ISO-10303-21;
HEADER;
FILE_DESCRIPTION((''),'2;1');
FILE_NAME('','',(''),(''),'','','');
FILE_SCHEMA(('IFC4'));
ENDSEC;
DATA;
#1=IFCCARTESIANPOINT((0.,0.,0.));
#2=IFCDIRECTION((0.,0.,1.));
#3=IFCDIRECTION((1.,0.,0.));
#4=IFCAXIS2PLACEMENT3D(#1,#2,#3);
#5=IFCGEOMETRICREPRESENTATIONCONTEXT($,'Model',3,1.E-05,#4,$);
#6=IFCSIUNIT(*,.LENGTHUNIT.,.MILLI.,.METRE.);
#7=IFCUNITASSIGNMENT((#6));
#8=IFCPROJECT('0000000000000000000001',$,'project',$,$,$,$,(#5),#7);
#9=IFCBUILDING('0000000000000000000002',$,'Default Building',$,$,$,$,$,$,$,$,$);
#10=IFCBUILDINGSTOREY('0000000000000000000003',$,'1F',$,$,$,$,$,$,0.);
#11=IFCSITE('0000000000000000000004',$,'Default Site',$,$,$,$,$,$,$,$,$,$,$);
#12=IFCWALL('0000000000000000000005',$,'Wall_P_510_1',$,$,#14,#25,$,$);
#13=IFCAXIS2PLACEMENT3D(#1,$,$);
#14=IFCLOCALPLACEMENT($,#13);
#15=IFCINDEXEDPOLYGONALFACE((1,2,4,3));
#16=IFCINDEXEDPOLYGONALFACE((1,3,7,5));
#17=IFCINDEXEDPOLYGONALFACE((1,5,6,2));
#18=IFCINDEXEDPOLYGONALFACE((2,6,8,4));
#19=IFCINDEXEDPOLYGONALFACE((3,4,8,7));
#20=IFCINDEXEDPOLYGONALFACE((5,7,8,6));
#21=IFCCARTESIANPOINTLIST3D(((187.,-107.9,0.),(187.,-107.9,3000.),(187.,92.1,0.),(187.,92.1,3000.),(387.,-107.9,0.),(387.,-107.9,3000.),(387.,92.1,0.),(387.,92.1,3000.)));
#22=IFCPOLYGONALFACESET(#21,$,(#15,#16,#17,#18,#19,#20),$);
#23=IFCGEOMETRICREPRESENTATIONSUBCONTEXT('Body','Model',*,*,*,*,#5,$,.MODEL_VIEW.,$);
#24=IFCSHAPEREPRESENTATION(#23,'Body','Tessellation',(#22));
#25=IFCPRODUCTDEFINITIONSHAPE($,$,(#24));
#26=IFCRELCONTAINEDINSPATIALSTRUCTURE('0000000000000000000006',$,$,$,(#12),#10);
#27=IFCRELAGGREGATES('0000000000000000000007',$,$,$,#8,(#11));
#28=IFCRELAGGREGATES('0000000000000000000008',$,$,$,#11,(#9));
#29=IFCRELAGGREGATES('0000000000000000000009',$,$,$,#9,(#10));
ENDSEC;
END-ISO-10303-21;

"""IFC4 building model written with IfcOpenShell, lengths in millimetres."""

from ifc_helpers import new_model, si_unit, frame, origin_with_axes, place, context, subcontext, project, spatial, indexed_curve, outline, extrude, element, save


model = new_model("IFC4")

# Units and contexts
model_context = context("Model", 3, precision=1e-05, world=origin_with_axes())
body_context = subcontext(model_context, "Body", "Model", "MODEL_VIEW")
ifc_project = project(units=[si_unit("LENGTHUNIT", "METRE", prefix="MILLI")], contexts=[model_context])

# Site, building, storey
site = spatial("IfcSite", under=ifc_project, Name="Default Site")
building = spatial("IfcBuilding", under=site, Name="Default Building")
storey = spatial("IfcBuildingStorey", under=building, Name="1F", Elevation=0.0)

# Wall
wall_1_placement = place(None, frame((187.0, 92.1, 0.0), z_axis=(0.0, 0.0, 1.0), x_axis=(0.0, -1.0, 0.0)))
element("IfcWall", 1, at=wall_1_placement, inside=storey, Name="Wall_P_510_1", context=body_context, shape_type="SweptSolid", body=[
    extrude(outline(indexed_curve([(0.0, 0.0), (0.0, 200.0), (200.0, 200.0), (200.0, 0.0), (0.0, 0.0)], self_intersect=False)), origin_with_axes(), (0.0, 0.0, 1.0), 3000.0),
])

save(model, "model.ifc")
